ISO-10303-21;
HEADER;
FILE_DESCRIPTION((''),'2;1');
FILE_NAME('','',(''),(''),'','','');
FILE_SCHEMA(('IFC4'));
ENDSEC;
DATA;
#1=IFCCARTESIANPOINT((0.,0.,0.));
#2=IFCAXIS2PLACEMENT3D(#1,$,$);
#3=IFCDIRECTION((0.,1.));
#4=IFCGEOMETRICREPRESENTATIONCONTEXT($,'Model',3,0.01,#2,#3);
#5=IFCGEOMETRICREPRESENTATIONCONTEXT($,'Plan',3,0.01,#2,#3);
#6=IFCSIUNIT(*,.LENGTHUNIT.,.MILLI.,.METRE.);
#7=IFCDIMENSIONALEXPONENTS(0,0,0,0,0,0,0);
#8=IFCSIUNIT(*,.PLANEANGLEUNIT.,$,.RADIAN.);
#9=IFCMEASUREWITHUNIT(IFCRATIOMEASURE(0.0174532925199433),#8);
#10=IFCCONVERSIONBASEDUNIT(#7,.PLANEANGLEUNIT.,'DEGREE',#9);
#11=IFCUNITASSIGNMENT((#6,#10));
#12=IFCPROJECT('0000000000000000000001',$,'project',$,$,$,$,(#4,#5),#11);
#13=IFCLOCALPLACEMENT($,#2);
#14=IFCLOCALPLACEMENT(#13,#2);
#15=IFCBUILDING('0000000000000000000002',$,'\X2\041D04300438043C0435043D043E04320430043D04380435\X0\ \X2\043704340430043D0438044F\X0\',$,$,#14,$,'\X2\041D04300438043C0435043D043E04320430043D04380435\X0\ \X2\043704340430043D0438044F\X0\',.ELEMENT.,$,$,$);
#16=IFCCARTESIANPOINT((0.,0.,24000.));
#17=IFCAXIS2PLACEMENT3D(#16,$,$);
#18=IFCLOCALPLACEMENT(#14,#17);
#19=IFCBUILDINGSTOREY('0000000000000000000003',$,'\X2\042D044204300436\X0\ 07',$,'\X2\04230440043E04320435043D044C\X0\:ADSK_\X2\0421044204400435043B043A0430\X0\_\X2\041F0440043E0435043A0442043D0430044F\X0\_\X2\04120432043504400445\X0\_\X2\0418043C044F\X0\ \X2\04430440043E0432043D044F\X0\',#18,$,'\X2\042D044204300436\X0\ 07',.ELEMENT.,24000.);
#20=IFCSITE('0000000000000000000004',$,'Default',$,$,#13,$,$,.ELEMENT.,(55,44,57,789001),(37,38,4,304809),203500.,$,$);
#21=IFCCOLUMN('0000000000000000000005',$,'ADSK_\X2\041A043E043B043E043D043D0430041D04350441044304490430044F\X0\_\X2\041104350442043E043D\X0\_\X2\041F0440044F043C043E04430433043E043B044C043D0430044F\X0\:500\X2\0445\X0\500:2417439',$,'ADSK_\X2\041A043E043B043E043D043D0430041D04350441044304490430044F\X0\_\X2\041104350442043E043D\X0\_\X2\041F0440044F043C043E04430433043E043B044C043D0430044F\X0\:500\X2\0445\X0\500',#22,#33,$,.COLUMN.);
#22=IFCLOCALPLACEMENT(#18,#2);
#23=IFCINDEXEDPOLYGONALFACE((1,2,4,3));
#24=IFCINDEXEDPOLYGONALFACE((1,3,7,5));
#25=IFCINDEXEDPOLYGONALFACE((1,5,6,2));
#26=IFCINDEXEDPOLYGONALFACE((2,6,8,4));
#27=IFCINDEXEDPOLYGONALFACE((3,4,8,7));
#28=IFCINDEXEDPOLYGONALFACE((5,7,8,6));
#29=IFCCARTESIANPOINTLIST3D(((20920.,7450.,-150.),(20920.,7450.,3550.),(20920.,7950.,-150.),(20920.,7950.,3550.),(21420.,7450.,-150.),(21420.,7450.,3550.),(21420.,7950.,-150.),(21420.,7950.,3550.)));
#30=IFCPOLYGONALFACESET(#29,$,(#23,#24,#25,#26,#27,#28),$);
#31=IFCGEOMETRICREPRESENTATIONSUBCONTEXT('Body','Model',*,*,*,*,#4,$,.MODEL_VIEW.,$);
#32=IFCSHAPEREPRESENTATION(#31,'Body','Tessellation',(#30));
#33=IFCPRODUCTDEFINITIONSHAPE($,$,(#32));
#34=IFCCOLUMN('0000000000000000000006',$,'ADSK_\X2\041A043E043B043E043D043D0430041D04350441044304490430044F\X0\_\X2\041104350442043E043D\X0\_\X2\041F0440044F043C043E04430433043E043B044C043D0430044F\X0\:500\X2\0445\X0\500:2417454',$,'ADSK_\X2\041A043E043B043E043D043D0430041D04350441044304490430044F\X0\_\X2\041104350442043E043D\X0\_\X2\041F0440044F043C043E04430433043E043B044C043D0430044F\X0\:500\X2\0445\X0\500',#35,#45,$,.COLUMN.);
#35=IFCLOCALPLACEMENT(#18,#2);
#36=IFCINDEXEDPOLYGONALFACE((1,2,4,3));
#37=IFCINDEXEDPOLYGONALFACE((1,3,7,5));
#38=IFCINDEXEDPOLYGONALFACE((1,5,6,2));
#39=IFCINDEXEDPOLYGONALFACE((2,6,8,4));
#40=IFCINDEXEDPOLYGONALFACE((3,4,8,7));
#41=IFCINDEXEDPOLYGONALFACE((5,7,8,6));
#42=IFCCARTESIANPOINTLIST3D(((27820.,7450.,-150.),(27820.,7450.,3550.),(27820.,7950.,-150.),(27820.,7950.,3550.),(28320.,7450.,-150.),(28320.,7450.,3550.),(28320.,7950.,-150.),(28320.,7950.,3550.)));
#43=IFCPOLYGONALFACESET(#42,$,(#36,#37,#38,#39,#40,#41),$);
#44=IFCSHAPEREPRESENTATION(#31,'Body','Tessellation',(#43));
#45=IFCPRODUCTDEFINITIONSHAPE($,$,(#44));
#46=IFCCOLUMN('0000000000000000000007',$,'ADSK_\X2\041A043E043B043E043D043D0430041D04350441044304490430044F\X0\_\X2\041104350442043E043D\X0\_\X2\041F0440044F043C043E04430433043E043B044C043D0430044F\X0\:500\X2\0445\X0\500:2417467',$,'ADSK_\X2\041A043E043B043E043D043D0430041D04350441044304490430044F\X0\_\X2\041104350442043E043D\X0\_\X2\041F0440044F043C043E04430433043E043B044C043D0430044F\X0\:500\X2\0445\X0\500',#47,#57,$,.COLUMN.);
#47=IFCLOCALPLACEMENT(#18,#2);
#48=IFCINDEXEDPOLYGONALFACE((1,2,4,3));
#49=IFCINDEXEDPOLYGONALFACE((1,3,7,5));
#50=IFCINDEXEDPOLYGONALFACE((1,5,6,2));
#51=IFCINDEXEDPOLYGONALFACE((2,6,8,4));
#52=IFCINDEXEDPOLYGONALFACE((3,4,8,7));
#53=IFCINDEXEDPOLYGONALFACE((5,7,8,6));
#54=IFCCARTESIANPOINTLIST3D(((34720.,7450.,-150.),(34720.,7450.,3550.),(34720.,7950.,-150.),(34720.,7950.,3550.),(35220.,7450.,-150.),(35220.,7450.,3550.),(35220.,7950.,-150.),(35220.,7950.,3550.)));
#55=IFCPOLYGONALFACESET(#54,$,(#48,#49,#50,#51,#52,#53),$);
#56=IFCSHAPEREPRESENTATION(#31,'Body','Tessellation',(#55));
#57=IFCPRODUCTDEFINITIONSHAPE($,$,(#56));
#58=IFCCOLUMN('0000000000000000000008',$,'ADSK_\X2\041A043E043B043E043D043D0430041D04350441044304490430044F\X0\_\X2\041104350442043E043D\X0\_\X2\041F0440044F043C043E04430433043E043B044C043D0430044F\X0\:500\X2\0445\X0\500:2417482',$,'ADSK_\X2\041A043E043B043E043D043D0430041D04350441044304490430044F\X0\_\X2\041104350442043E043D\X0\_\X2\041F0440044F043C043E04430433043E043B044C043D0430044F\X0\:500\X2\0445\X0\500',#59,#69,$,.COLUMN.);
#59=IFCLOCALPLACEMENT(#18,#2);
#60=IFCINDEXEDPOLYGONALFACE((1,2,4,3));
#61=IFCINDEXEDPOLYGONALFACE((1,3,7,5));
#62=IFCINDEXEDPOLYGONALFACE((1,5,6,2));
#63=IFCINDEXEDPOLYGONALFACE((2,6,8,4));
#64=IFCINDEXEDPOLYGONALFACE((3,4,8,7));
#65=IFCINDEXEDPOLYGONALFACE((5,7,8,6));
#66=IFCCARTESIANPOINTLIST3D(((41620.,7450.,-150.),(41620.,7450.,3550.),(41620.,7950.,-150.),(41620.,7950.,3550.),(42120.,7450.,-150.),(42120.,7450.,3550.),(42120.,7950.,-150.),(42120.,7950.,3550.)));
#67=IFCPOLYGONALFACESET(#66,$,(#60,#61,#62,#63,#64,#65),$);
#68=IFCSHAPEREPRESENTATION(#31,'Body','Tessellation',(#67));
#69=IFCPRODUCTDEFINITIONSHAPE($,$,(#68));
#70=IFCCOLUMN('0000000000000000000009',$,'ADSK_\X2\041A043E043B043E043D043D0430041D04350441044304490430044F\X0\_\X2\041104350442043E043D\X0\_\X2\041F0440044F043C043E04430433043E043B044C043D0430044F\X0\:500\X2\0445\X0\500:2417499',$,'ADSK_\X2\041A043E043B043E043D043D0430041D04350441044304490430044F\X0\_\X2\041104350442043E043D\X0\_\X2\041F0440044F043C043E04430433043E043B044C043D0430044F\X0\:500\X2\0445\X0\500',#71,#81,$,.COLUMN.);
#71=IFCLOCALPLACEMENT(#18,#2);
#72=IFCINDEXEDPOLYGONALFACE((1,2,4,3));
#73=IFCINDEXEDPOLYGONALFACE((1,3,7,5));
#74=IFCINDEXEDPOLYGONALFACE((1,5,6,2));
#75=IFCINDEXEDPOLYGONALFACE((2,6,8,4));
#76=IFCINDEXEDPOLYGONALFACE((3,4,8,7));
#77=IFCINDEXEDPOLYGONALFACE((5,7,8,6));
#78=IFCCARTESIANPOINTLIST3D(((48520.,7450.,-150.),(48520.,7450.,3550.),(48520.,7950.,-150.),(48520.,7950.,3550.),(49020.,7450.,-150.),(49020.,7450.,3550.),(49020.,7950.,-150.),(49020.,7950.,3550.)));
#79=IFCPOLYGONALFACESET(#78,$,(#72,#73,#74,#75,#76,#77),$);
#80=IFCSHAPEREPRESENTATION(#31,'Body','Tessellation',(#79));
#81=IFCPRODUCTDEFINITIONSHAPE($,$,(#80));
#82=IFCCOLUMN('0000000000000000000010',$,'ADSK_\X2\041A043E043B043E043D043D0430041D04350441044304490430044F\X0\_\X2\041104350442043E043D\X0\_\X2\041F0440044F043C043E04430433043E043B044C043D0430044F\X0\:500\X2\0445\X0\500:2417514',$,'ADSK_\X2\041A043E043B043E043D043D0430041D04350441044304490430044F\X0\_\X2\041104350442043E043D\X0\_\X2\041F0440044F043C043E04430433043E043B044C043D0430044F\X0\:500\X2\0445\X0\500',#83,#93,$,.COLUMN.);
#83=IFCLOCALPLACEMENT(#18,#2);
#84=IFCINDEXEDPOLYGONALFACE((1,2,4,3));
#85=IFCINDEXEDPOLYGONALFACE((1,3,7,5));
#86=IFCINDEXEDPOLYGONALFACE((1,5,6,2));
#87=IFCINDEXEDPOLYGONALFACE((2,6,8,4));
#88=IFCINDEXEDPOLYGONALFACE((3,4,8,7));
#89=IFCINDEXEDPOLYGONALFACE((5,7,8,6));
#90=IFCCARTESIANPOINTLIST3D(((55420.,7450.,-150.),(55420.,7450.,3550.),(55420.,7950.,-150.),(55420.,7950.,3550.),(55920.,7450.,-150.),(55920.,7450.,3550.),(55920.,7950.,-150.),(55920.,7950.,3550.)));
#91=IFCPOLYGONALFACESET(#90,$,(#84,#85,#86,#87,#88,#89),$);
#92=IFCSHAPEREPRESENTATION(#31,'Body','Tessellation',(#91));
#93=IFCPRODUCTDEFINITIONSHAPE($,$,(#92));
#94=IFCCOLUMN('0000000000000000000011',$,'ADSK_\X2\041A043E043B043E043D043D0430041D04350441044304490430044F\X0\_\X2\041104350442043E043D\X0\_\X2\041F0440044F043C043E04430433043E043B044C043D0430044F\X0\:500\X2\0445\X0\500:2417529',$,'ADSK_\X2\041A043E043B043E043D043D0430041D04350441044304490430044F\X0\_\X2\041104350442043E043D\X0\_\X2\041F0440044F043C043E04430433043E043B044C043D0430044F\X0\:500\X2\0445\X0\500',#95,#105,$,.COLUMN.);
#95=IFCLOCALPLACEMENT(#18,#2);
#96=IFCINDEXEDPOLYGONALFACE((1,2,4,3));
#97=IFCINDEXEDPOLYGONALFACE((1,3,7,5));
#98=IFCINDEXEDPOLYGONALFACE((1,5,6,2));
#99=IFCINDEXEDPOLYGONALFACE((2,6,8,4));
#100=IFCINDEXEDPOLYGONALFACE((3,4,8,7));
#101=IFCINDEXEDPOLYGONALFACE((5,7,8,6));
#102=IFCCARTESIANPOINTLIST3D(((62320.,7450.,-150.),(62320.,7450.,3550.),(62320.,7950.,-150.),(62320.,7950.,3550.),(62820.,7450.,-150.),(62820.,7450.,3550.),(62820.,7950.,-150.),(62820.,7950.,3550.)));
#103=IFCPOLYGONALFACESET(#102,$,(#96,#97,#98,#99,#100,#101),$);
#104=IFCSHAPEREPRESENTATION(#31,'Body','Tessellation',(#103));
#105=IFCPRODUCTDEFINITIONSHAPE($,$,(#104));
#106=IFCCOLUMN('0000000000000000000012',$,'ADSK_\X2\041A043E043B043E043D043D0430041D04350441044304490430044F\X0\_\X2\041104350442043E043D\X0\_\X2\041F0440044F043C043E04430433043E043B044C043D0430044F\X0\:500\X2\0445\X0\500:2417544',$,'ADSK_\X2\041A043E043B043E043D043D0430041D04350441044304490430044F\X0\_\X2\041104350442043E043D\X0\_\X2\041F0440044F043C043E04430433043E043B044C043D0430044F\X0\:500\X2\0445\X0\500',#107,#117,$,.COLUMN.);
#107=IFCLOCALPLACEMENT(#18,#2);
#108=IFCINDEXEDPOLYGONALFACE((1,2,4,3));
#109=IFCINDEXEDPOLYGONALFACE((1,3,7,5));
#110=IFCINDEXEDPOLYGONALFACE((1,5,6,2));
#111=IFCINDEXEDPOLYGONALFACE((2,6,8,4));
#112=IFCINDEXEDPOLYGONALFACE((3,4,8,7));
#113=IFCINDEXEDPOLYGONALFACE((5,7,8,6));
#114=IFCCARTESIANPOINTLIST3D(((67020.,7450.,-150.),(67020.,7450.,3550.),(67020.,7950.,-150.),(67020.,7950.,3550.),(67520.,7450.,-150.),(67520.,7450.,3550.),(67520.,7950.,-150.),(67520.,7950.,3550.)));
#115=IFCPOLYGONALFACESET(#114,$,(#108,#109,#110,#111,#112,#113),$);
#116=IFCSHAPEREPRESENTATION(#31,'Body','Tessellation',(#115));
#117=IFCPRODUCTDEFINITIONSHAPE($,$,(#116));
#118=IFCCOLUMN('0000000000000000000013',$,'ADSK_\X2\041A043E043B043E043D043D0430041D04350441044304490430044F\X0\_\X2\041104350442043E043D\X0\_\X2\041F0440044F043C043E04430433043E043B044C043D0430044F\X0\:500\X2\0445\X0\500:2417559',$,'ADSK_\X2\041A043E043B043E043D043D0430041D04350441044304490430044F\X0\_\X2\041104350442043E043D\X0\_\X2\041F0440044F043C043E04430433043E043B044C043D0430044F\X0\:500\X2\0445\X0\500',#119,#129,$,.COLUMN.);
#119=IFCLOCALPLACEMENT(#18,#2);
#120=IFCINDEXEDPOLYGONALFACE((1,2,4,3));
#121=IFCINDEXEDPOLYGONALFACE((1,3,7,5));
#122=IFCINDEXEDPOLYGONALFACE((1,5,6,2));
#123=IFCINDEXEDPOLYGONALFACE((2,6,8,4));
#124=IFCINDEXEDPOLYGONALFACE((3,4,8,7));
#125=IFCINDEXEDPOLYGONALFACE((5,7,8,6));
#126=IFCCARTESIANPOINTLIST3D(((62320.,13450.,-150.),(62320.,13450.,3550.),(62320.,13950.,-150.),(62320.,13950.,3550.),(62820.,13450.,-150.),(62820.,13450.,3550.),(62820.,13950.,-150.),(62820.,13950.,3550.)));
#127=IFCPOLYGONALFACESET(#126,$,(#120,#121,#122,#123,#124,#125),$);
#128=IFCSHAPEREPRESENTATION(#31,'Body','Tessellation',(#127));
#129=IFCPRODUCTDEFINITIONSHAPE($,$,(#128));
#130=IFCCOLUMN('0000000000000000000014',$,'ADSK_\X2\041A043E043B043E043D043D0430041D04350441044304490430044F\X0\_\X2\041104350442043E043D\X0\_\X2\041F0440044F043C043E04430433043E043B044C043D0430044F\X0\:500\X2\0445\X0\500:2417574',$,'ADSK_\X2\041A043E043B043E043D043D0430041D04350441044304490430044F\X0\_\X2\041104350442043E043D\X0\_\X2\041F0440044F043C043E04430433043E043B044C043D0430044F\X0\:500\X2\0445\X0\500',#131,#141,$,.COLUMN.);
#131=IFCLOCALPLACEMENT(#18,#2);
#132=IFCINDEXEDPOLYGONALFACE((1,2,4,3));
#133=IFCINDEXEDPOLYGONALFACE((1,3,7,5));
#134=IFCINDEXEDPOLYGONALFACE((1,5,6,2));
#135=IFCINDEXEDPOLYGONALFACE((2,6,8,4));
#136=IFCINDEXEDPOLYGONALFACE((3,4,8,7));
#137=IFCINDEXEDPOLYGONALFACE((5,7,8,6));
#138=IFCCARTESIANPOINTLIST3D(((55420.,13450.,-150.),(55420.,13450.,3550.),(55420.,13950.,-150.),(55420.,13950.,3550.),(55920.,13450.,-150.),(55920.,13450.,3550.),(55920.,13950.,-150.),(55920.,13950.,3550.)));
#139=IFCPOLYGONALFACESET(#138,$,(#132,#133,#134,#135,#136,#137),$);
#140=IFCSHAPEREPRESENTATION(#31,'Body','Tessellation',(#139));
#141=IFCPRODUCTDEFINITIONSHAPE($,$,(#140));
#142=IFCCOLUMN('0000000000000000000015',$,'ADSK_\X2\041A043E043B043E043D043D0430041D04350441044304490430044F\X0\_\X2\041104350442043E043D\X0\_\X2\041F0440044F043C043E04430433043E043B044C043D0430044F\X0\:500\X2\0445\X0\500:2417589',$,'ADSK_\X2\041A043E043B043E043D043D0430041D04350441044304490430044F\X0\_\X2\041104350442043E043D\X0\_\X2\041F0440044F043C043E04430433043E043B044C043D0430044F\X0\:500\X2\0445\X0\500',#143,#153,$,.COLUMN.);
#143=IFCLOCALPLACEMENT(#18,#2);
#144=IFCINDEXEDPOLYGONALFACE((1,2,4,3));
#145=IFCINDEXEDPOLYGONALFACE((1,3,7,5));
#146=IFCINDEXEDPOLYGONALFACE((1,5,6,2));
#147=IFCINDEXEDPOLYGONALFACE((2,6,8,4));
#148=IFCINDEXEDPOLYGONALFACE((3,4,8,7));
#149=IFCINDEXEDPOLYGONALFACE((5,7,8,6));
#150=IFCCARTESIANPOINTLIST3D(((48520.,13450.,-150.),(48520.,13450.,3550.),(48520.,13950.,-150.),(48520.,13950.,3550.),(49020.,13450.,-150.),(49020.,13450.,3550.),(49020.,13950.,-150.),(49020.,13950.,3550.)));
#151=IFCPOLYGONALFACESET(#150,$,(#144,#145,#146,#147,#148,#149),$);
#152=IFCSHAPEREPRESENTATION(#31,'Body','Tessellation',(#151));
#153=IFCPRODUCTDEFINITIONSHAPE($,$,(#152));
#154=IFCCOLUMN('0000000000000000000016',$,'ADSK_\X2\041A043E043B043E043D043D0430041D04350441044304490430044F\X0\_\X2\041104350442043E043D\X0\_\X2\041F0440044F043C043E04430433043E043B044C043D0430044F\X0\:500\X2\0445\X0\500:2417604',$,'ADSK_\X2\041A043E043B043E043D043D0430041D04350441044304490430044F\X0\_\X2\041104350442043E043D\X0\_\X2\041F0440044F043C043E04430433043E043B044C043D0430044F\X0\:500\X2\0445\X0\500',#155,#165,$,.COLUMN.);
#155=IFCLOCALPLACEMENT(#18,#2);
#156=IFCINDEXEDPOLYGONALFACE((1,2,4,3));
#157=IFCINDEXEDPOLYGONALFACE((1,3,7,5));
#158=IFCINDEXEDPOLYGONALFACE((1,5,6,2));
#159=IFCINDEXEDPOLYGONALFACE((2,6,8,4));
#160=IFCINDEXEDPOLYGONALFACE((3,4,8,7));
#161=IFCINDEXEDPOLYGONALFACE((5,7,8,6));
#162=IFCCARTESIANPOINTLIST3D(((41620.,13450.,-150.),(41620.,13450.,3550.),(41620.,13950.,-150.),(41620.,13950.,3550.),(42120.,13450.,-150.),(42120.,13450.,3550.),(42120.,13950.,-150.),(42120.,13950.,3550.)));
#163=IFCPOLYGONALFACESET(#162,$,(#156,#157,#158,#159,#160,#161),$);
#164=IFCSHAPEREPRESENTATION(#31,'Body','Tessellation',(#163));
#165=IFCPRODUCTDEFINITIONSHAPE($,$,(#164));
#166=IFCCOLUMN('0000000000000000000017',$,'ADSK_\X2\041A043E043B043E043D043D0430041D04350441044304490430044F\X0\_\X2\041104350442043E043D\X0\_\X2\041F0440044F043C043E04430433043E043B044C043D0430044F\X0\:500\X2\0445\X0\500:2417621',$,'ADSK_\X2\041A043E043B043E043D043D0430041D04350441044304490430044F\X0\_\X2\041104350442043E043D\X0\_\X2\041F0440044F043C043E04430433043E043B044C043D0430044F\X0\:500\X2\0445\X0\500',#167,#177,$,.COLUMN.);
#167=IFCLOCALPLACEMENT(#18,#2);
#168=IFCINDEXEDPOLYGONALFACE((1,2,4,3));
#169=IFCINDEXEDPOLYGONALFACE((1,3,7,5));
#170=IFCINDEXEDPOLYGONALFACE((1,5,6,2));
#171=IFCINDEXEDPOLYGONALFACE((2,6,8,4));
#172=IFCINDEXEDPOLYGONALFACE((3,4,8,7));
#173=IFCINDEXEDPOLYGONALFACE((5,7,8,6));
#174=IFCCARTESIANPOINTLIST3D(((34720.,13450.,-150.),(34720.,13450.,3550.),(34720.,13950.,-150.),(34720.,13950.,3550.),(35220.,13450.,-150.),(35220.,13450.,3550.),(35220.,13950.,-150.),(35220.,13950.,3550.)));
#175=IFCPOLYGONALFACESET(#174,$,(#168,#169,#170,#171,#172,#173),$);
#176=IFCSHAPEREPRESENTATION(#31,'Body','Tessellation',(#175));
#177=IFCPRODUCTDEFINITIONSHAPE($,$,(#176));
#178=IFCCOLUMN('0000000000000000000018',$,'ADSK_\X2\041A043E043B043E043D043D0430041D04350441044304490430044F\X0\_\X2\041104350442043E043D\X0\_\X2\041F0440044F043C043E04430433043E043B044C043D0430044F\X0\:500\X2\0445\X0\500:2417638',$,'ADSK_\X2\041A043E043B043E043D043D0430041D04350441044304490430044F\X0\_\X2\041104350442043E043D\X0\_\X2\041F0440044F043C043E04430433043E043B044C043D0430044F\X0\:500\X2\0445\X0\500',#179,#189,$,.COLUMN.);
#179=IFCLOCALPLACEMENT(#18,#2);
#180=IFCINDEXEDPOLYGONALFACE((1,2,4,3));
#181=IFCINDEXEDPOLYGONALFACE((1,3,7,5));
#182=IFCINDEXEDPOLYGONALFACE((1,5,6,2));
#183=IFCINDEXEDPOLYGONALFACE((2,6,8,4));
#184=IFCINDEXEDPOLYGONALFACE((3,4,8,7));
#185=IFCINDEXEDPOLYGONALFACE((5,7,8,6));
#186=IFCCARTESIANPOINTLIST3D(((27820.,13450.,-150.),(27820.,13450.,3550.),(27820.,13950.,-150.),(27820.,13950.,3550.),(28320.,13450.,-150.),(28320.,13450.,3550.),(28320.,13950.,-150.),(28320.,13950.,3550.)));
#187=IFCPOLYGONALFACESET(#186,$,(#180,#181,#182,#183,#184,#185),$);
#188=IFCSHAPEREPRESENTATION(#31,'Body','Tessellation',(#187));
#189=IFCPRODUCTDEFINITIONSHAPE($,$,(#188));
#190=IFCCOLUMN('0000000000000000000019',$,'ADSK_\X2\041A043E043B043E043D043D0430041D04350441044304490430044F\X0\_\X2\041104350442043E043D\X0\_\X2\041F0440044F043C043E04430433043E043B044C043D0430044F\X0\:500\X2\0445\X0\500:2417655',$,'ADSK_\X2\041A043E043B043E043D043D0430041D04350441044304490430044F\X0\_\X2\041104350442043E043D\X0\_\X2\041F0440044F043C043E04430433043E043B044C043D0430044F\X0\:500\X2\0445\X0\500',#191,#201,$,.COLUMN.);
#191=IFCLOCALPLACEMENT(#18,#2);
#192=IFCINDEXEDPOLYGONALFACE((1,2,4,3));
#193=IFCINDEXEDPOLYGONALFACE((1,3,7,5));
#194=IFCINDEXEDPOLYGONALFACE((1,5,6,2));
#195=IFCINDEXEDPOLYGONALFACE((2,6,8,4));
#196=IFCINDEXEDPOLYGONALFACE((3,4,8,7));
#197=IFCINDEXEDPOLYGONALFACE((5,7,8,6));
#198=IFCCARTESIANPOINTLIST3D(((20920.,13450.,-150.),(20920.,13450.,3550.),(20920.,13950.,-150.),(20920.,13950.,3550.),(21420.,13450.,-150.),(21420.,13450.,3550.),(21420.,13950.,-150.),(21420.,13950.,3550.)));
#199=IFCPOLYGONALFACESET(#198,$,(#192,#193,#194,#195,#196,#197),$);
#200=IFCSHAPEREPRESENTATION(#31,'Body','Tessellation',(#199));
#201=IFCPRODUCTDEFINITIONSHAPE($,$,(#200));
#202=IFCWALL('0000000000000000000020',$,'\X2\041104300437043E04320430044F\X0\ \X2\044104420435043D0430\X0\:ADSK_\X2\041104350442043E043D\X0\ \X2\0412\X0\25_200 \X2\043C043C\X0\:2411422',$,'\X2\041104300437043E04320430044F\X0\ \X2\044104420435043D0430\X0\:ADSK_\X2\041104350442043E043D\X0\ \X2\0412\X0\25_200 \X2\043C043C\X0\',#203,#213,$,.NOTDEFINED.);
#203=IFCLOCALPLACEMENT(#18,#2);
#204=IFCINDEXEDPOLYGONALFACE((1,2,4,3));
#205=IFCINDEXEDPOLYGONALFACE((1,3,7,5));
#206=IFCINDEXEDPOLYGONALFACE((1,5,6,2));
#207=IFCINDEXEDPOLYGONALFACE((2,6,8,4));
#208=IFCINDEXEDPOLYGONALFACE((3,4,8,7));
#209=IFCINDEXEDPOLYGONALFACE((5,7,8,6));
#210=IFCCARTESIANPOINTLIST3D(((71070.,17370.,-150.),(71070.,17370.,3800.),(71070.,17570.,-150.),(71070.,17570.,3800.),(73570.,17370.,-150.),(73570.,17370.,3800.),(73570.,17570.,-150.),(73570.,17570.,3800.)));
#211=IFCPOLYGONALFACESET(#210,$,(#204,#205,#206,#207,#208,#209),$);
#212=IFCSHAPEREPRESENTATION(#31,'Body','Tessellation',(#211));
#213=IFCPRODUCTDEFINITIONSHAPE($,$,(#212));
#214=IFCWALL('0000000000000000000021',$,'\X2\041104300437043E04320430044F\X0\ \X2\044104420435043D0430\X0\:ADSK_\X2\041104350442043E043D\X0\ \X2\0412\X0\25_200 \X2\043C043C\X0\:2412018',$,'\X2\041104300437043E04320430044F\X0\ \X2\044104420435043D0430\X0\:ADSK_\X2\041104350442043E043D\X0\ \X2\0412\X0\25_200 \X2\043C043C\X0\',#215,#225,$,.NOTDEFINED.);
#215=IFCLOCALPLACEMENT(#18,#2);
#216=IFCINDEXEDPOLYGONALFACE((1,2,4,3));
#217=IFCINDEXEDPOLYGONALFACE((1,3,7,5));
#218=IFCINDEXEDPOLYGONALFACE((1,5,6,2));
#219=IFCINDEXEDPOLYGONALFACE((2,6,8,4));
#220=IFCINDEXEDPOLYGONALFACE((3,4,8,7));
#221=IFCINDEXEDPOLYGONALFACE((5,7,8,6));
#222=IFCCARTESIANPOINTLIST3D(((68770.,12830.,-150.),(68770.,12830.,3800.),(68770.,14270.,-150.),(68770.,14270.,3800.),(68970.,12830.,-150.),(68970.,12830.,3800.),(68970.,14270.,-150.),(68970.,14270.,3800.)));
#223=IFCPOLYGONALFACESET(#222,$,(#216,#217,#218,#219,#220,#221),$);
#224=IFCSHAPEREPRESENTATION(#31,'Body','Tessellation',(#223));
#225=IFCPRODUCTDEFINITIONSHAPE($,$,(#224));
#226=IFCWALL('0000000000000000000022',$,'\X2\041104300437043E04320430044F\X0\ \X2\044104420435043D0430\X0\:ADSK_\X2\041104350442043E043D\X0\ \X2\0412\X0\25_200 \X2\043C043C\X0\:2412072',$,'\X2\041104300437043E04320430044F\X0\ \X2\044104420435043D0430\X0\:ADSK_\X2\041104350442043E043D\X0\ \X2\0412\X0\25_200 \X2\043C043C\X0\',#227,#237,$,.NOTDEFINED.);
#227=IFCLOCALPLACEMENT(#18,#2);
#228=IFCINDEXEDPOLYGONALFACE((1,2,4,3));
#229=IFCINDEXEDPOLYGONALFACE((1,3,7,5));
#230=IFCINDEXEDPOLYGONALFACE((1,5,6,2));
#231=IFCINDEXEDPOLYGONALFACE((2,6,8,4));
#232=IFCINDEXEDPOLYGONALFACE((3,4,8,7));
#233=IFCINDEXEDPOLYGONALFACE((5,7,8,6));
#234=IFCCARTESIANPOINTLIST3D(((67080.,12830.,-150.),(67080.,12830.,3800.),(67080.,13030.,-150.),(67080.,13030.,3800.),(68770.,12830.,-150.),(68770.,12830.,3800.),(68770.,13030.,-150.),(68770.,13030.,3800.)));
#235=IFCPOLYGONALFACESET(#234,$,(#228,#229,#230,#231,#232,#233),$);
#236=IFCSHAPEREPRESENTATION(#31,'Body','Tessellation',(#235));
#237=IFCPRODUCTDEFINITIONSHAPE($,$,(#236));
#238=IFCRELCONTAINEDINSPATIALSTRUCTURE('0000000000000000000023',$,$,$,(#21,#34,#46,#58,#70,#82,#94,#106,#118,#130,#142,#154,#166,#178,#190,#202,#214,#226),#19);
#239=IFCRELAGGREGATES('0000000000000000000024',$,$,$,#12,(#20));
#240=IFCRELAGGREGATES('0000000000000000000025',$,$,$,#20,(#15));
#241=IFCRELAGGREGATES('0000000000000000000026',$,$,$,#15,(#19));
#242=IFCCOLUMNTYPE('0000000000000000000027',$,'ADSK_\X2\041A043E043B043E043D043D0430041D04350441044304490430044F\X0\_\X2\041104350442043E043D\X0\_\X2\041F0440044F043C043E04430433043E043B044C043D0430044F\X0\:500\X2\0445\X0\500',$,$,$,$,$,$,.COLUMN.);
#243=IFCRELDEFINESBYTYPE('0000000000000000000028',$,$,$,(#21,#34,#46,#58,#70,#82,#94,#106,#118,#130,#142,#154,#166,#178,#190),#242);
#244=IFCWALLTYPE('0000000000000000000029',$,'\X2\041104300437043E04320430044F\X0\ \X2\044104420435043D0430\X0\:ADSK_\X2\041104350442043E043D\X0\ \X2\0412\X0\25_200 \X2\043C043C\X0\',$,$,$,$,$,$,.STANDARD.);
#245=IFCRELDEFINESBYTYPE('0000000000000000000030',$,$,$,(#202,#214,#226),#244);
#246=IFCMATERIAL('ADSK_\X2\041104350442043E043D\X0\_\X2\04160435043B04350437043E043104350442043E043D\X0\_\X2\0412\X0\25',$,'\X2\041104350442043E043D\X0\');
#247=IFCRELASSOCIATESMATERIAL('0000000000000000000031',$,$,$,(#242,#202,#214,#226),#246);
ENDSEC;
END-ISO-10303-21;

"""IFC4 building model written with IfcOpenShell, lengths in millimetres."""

from ifc_helpers import new_model, entity, si_unit, converted_unit, direction, frame, origin, place, context, subcontext, project, spatial, indexed_curve, outline, extrude, source, transform, mapped, material, type_object, type_shapes, element, save


model = new_model("IFC4")

# Units and contexts
model_context = context("Model", 3, precision=0.01, world=origin(), true_north=direction((0.0, 1.0)))
plan_context = context("Plan", 3, precision=0.01, world=origin(), true_north=direction((0.0, 1.0)))
body_context = subcontext(model_context, "Body", "Model", "MODEL_VIEW")
ifc_project = project(units=[si_unit("LENGTHUNIT", "METRE", prefix="MILLI"), converted_unit("PLANEANGLEUNIT", "DEGREE", entity("IfcRatioMeasure", 0.0174532925199433), si_unit("PLANEANGLEUNIT", "RADIAN"), dimensions=[0, 0, 0, 0, 0, 0, 0])], contexts=[model_context, plan_context])

# Site, building, storey
site_placement = place(None, origin())
site = spatial("IfcSite", under=ifc_project, at=site_placement, Name="Default", CompositionType="ELEMENT", RefLatitude=(55, 44, 57, 789001), RefLongitude=(37, 38, 4, 304809), RefElevation=203500.0)
building_placement = place(site_placement, origin())
building = spatial("IfcBuilding", under=site, at=building_placement, Name="Наименование здания", LongName="Наименование здания", CompositionType="ELEMENT")
storey_placement = place(building_placement, frame((0.0, 0.0, 24000.0)))
storey = spatial("IfcBuildingStorey", under=building, at=storey_placement, Name="Этаж 07", ObjectType="Уровень:ADSK_Стрелка_Проектная_Вверх_Имя уровня", LongName="Этаж 07", CompositionType="ELEMENT", Elevation=24000.0)

# Columns
ifc_material = material(Name="ADSK_Бетон_Железобетон_В25", Category="Бетон")
column_type = type_object("IfcColumnType", Name="ADSK_КолоннаНесущая_Бетон_Прямоугольная:500х500", PredefinedType="COLUMN", material=ifc_material)
shared_shape = source(origin(), body_context, "Body", "SweptSolid", [
    extrude(outline(indexed_curve([(-250.0, -250.0), (250.0, -250.0), (250.0, 250.0), (-250.0, 250.0), (-250.0, -250.0)], self_intersect=False)), frame((0.0, 0.0, 23850.0), z_axis=(0.0, 0.0, 1.0), x_axis=(0.0, -1.0, 0.0)), (0.0, 0.0, 1.0), 3700.0),
])
type_shapes(column_type, [shared_shape])
for number, where, name in (
    (1, (21170.0, 7700.0, -24000.0), "ADSK_КолоннаНесущая_Бетон_Прямоугольная:500х500:2417439"),
    (2, (28070.0, 7700.0, -24000.0), "ADSK_КолоннаНесущая_Бетон_Прямоугольная:500х500:2417454"),
    (3, (34970.0, 7700.0, -24000.0), "ADSK_КолоннаНесущая_Бетон_Прямоугольная:500х500:2417467"),
    (4, (41870.0, 7700.0, -24000.0), "ADSK_КолоннаНесущая_Бетон_Прямоугольная:500х500:2417482"),
    (5, (48770.0, 7700.0, -24000.0), "ADSK_КолоннаНесущая_Бетон_Прямоугольная:500х500:2417499"),
    (6, (55670.0, 7700.0, -24000.0), "ADSK_КолоннаНесущая_Бетон_Прямоугольная:500х500:2417514"),
    (7, (62570.0, 7700.0, -24000.0), "ADSK_КолоннаНесущая_Бетон_Прямоугольная:500х500:2417529"),
    (8, (67270.0, 7700.0, -24000.0), "ADSK_КолоннаНесущая_Бетон_Прямоугольная:500х500:2417544"),
    (9, (62570.0, 13700.0, -24000.0), "ADSK_КолоннаНесущая_Бетон_Прямоугольная:500х500:2417559"),
    (10, (55670.0, 13700.0, -24000.0), "ADSK_КолоннаНесущая_Бетон_Прямоугольная:500х500:2417574"),
    (11, (48770.0, 13700.0, -24000.0), "ADSK_КолоннаНесущая_Бетон_Прямоугольная:500х500:2417589"),
    (12, (41870.0, 13700.0, -24000.0), "ADSK_КолоннаНесущая_Бетон_Прямоугольная:500х500:2417604"),
    (13, (34970.0, 13700.0, -24000.0), "ADSK_КолоннаНесущая_Бетон_Прямоугольная:500х500:2417621"),
    (14, (28070.0, 13700.0, -24000.0), "ADSK_КолоннаНесущая_Бетон_Прямоугольная:500х500:2417638"),
    (15, (21170.0, 13700.0, -24000.0), "ADSK_КолоннаНесущая_Бетон_Прямоугольная:500х500:2417655"),
):
    element("IfcColumn", number, at=place(storey_placement, frame(where)), inside=storey, type_object=column_type, Name=name, ObjectType="ADSK_КолоннаНесущая_Бетон_Прямоугольная:500х500", PredefinedType="COLUMN", context=body_context, shape_type="MappedRepresentation", body=[
        mapped(shared_shape, transform((0.0, 0.0, 0.0), scale=1.0)),
    ])

# Walls
wall_type = type_object("IfcWallType", Name="Базовая стена:ADSK_Бетон В25_200 мм", PredefinedType="STANDARD")
wall_1_placement = place(storey_placement, frame((71070.0, 17470.0, -150.0)))
element("IfcWall", 16, at=wall_1_placement, inside=storey, type_object=wall_type, material=ifc_material, Name="Базовая стена:ADSK_Бетон В25_200 мм:2411422", ObjectType="Базовая стена:ADSK_Бетон В25_200 мм", PredefinedType="NOTDEFINED", context=body_context, shape_type="SweptSolid", body=[
    extrude(outline(indexed_curve([(2500.0, 100.0), (0.0, 100.0), (0.0, -100.0), (2500.0, -100.0), (2500.0, 100.0)], self_intersect=False)), origin(), (0.0, 0.0, 1.0), 3950.0),
])
wall_2_placement = place(storey_placement, frame((68870.0, 14270.0, -150.0), z_axis=(0.0, 0.0, 1.0), x_axis=(0.0, -1.0, 0.0)))
element("IfcWall", 17, at=wall_2_placement, inside=storey, type_object=wall_type, material=ifc_material, Name="Базовая стена:ADSK_Бетон В25_200 мм:2412018", ObjectType="Базовая стена:ADSK_Бетон В25_200 мм", PredefinedType="NOTDEFINED", context=body_context, shape_type="SweptSolid", body=[
    extrude(outline(indexed_curve([(1440.0, 100.0), (0.0, 100.0), (0.0, -100.0), (1440.0, -100.0), (1440.0, 100.0)], self_intersect=False)), origin(), (0.0, 0.0, 1.0), 3950.0),
])
wall_3_placement = place(storey_placement, frame((68770.0, 12930.0, -150.0), z_axis=(0.0, 0.0, 1.0), x_axis=(-1.0, 0.0, 0.0)))
element("IfcWall", 18, at=wall_3_placement, inside=storey, type_object=wall_type, material=ifc_material, Name="Базовая стена:ADSK_Бетон В25_200 мм:2412072", ObjectType="Базовая стена:ADSK_Бетон В25_200 мм", PredefinedType="NOTDEFINED", context=body_context, shape_type="SweptSolid", body=[
    extrude(outline(indexed_curve([(1690.0, 100.0), (0.0, 100.0), (0.0, -100.0), (1690.0, -100.0), (1690.0, 100.0)], self_intersect=False)), origin(), (0.0, 0.0, 1.0), 3950.0),
])

save(model, "model.ifc")
